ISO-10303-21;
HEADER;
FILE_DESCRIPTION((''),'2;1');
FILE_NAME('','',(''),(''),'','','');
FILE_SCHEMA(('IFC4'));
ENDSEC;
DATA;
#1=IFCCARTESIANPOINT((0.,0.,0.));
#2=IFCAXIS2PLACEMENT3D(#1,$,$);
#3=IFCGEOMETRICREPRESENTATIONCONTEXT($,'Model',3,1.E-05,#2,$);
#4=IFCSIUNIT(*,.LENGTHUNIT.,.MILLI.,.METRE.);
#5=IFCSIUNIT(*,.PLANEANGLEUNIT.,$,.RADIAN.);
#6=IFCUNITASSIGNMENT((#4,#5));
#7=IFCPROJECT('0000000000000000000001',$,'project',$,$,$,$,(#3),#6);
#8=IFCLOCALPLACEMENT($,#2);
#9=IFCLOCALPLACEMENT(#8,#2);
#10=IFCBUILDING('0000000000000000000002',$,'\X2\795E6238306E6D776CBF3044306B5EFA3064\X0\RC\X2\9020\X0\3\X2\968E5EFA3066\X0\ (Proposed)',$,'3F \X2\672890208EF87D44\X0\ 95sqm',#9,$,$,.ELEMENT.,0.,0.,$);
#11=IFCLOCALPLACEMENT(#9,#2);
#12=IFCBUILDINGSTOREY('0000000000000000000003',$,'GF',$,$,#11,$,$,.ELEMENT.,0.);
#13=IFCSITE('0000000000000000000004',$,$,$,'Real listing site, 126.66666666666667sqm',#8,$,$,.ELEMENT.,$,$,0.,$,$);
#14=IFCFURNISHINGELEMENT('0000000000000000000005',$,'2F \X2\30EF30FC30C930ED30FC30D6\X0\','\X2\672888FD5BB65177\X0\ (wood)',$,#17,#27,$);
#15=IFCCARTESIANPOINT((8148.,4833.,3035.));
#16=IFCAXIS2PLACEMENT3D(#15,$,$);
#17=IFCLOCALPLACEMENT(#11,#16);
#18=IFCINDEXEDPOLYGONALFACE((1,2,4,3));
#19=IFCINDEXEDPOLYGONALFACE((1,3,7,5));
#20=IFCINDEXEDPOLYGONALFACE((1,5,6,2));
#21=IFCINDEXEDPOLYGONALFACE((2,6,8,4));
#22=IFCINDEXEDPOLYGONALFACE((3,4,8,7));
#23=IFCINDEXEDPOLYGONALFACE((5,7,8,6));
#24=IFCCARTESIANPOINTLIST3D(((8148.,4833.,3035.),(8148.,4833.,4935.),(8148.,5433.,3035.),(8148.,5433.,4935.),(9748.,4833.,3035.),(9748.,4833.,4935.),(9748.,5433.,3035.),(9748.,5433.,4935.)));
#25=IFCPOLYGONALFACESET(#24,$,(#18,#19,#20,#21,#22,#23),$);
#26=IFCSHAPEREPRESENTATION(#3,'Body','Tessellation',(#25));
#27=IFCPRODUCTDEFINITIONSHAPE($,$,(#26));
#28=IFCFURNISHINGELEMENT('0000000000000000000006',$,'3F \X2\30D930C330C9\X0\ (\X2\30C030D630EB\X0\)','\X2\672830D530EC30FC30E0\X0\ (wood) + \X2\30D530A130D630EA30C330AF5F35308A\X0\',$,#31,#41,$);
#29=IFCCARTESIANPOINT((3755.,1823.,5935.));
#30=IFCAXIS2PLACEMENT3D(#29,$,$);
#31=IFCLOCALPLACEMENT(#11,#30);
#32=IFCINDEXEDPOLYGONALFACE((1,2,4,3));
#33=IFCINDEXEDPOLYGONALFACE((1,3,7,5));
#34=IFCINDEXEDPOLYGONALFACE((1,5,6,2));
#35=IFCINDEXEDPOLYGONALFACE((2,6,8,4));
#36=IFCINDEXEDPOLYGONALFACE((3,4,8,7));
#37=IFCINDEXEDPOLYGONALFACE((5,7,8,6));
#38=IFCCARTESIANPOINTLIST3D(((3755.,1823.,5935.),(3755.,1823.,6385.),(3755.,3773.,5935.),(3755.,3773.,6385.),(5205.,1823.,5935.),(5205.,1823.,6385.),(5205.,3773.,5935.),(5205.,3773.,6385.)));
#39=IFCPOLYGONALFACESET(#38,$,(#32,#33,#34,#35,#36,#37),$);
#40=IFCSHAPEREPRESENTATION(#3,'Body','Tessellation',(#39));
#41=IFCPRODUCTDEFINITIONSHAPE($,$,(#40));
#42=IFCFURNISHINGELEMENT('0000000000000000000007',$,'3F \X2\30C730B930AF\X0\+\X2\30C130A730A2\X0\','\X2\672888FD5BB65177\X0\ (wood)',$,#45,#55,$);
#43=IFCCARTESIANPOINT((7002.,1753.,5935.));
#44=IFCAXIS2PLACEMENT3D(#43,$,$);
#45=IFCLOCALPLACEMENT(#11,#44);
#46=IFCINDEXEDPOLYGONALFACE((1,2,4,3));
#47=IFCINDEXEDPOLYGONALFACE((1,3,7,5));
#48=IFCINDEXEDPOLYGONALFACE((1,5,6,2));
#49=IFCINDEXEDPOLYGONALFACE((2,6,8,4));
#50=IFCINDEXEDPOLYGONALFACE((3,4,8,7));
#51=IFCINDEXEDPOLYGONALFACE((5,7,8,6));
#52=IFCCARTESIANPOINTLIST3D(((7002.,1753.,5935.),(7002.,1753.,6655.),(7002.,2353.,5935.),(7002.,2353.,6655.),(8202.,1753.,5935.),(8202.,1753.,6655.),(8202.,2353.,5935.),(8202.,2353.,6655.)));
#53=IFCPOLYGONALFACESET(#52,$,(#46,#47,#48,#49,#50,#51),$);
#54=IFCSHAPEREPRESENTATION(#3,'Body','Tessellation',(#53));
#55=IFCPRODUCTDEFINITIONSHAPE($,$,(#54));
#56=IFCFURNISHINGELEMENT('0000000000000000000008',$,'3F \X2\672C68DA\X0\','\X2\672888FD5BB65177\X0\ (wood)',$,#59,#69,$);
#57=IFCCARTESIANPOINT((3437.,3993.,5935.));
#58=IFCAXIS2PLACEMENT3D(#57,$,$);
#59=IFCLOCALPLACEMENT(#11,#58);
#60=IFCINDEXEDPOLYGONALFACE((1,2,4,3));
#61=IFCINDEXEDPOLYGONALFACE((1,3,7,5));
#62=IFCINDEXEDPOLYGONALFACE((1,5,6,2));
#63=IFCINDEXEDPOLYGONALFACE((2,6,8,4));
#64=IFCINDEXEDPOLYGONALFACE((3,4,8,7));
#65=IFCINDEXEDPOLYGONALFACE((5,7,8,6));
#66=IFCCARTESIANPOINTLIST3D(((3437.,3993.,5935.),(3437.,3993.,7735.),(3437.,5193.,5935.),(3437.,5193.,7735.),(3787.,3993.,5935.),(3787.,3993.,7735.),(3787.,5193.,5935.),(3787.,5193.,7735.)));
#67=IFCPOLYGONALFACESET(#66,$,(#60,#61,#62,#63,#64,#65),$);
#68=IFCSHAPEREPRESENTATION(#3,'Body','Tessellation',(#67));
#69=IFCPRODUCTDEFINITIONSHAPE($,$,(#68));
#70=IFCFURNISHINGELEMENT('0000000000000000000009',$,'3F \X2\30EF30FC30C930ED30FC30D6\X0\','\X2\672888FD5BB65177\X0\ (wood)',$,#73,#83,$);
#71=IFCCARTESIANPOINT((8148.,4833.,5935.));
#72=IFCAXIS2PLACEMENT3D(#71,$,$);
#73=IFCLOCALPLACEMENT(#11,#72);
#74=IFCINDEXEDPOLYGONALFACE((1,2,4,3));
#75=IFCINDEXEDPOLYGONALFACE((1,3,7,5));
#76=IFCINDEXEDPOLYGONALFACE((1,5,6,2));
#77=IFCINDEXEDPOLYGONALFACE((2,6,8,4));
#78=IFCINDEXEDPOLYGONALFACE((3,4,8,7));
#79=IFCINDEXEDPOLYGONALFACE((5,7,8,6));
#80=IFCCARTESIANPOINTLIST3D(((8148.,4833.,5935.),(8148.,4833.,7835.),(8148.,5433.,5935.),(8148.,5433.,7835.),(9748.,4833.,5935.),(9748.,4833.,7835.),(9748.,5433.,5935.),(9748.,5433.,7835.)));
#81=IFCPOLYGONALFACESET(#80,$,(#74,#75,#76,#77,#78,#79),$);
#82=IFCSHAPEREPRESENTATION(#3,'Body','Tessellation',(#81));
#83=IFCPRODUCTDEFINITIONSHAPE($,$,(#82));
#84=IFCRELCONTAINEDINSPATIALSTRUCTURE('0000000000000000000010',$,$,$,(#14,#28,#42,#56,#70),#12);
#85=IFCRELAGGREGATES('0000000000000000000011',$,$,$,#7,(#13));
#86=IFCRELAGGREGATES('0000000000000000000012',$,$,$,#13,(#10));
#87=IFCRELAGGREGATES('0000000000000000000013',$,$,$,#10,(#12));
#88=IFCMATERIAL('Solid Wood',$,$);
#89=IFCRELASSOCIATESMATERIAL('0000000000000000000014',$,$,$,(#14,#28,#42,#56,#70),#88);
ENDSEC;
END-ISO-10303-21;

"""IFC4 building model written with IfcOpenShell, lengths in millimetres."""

from ifc_helpers import new_model, si_unit, frame, frame_2d, origin, place, context, project, spatial, rectangle, extrude, material, element, save


model = new_model("IFC4")

# Units and contexts
model_context = context("Model", 3, precision=1e-05, world=origin())
ifc_project = project(units=[si_unit("LENGTHUNIT", "METRE", prefix="MILLI"), si_unit("PLANEANGLEUNIT", "RADIAN")], contexts=[model_context])

# Site, building, storey
site_placement = place(None, origin())
site = spatial("IfcSite", under=ifc_project, at=site_placement, ObjectType="Real listing site, 126.66666666666667sqm", CompositionType="ELEMENT", RefElevation=0.0)
building_placement = place(site_placement, origin())
building = spatial("IfcBuilding", under=site, at=building_placement, Name="神戸の海沿いに建つRC造3階建て (Proposed)", ObjectType="3F 木造軸組 95sqm", CompositionType="ELEMENT", ElevationOfRefHeight=0.0, ElevationOfTerrain=0.0)
storey_placement = place(building_placement, origin())
storey = spatial("IfcBuildingStorey", under=building, at=storey_placement, Name="GF", CompositionType="ELEMENT", Elevation=0.0)

# Shared definitions
ifc_material_1 = material(Name="Solid Wood")

# Furnishing elements
furnishing_1_placement = place(storey_placement, frame((8148.0, 4833.0, 3035.0)))
element("IfcFurnishingElement", 1, at=furnishing_1_placement, inside=storey, material=ifc_material_1, Name="2F ワードローブ", Description="木製家具 (wood)", context=model_context, shape_type="SweptSolid", body=[
    extrude(rectangle(XDim=1600.0, YDim=600.0, at=frame_2d((800.0, 300.0))), frame((8148.0, 4833.0, 3035.0)), (0.0, 0.0, 1.0), 1900.0),
])
furnishing_2_placement = place(storey_placement, frame((3755.0, 1823.0, 5935.0)))
element("IfcFurnishingElement", 2, at=furnishing_2_placement, inside=storey, material=ifc_material_1, Name="3F ベッド (ダブル)", Description="木フレーム (wood) + ファブリック張り", context=model_context, shape_type="SweptSolid", body=[
    extrude(rectangle(XDim=1450.0, YDim=1950.0, at=frame_2d((725.0, 975.0))), frame((3755.0, 1823.0, 5935.0)), (0.0, 0.0, 1.0), 450.0),
])
furnishing_3_placement = place(storey_placement, frame((7002.0, 1753.0, 5935.0)))
element("IfcFurnishingElement", 3, at=furnishing_3_placement, inside=storey, material=ifc_material_1, Name="3F デスク+チェア", Description="木製家具 (wood)", context=model_context, shape_type="SweptSolid", body=[
    extrude(rectangle(XDim=1200.0, YDim=600.0, at=frame_2d((600.0, 300.0))), frame((7002.0, 1753.0, 5935.0)), (0.0, 0.0, 1.0), 720.0),
])
furnishing_4_placement = place(storey_placement, frame((3437.0, 3993.0, 5935.0)))
element("IfcFurnishingElement", 4, at=furnishing_4_placement, inside=storey, material=ifc_material_1, Name="3F 本棚", Description="木製家具 (wood)", context=model_context, shape_type="SweptSolid", body=[
    extrude(rectangle(XDim=350.0, YDim=1200.0, at=frame_2d((175.0, 600.0))), frame((3437.0, 3993.0, 5935.0)), (0.0, 0.0, 1.0), 1800.0),
])
furnishing_5_placement = place(storey_placement, frame((8148.0, 4833.0, 5935.0)))
element("IfcFurnishingElement", 5, at=furnishing_5_placement, inside=storey, material=ifc_material_1, Name="3F ワードローブ", Description="木製家具 (wood)", context=model_context, shape_type="SweptSolid", body=[
    extrude(rectangle(XDim=1600.0, YDim=600.0, at=frame_2d((800.0, 300.0))), frame((8148.0, 4833.0, 5935.0)), (0.0, 0.0, 1.0), 1900.0),
])

save(model, "model.ifc")
